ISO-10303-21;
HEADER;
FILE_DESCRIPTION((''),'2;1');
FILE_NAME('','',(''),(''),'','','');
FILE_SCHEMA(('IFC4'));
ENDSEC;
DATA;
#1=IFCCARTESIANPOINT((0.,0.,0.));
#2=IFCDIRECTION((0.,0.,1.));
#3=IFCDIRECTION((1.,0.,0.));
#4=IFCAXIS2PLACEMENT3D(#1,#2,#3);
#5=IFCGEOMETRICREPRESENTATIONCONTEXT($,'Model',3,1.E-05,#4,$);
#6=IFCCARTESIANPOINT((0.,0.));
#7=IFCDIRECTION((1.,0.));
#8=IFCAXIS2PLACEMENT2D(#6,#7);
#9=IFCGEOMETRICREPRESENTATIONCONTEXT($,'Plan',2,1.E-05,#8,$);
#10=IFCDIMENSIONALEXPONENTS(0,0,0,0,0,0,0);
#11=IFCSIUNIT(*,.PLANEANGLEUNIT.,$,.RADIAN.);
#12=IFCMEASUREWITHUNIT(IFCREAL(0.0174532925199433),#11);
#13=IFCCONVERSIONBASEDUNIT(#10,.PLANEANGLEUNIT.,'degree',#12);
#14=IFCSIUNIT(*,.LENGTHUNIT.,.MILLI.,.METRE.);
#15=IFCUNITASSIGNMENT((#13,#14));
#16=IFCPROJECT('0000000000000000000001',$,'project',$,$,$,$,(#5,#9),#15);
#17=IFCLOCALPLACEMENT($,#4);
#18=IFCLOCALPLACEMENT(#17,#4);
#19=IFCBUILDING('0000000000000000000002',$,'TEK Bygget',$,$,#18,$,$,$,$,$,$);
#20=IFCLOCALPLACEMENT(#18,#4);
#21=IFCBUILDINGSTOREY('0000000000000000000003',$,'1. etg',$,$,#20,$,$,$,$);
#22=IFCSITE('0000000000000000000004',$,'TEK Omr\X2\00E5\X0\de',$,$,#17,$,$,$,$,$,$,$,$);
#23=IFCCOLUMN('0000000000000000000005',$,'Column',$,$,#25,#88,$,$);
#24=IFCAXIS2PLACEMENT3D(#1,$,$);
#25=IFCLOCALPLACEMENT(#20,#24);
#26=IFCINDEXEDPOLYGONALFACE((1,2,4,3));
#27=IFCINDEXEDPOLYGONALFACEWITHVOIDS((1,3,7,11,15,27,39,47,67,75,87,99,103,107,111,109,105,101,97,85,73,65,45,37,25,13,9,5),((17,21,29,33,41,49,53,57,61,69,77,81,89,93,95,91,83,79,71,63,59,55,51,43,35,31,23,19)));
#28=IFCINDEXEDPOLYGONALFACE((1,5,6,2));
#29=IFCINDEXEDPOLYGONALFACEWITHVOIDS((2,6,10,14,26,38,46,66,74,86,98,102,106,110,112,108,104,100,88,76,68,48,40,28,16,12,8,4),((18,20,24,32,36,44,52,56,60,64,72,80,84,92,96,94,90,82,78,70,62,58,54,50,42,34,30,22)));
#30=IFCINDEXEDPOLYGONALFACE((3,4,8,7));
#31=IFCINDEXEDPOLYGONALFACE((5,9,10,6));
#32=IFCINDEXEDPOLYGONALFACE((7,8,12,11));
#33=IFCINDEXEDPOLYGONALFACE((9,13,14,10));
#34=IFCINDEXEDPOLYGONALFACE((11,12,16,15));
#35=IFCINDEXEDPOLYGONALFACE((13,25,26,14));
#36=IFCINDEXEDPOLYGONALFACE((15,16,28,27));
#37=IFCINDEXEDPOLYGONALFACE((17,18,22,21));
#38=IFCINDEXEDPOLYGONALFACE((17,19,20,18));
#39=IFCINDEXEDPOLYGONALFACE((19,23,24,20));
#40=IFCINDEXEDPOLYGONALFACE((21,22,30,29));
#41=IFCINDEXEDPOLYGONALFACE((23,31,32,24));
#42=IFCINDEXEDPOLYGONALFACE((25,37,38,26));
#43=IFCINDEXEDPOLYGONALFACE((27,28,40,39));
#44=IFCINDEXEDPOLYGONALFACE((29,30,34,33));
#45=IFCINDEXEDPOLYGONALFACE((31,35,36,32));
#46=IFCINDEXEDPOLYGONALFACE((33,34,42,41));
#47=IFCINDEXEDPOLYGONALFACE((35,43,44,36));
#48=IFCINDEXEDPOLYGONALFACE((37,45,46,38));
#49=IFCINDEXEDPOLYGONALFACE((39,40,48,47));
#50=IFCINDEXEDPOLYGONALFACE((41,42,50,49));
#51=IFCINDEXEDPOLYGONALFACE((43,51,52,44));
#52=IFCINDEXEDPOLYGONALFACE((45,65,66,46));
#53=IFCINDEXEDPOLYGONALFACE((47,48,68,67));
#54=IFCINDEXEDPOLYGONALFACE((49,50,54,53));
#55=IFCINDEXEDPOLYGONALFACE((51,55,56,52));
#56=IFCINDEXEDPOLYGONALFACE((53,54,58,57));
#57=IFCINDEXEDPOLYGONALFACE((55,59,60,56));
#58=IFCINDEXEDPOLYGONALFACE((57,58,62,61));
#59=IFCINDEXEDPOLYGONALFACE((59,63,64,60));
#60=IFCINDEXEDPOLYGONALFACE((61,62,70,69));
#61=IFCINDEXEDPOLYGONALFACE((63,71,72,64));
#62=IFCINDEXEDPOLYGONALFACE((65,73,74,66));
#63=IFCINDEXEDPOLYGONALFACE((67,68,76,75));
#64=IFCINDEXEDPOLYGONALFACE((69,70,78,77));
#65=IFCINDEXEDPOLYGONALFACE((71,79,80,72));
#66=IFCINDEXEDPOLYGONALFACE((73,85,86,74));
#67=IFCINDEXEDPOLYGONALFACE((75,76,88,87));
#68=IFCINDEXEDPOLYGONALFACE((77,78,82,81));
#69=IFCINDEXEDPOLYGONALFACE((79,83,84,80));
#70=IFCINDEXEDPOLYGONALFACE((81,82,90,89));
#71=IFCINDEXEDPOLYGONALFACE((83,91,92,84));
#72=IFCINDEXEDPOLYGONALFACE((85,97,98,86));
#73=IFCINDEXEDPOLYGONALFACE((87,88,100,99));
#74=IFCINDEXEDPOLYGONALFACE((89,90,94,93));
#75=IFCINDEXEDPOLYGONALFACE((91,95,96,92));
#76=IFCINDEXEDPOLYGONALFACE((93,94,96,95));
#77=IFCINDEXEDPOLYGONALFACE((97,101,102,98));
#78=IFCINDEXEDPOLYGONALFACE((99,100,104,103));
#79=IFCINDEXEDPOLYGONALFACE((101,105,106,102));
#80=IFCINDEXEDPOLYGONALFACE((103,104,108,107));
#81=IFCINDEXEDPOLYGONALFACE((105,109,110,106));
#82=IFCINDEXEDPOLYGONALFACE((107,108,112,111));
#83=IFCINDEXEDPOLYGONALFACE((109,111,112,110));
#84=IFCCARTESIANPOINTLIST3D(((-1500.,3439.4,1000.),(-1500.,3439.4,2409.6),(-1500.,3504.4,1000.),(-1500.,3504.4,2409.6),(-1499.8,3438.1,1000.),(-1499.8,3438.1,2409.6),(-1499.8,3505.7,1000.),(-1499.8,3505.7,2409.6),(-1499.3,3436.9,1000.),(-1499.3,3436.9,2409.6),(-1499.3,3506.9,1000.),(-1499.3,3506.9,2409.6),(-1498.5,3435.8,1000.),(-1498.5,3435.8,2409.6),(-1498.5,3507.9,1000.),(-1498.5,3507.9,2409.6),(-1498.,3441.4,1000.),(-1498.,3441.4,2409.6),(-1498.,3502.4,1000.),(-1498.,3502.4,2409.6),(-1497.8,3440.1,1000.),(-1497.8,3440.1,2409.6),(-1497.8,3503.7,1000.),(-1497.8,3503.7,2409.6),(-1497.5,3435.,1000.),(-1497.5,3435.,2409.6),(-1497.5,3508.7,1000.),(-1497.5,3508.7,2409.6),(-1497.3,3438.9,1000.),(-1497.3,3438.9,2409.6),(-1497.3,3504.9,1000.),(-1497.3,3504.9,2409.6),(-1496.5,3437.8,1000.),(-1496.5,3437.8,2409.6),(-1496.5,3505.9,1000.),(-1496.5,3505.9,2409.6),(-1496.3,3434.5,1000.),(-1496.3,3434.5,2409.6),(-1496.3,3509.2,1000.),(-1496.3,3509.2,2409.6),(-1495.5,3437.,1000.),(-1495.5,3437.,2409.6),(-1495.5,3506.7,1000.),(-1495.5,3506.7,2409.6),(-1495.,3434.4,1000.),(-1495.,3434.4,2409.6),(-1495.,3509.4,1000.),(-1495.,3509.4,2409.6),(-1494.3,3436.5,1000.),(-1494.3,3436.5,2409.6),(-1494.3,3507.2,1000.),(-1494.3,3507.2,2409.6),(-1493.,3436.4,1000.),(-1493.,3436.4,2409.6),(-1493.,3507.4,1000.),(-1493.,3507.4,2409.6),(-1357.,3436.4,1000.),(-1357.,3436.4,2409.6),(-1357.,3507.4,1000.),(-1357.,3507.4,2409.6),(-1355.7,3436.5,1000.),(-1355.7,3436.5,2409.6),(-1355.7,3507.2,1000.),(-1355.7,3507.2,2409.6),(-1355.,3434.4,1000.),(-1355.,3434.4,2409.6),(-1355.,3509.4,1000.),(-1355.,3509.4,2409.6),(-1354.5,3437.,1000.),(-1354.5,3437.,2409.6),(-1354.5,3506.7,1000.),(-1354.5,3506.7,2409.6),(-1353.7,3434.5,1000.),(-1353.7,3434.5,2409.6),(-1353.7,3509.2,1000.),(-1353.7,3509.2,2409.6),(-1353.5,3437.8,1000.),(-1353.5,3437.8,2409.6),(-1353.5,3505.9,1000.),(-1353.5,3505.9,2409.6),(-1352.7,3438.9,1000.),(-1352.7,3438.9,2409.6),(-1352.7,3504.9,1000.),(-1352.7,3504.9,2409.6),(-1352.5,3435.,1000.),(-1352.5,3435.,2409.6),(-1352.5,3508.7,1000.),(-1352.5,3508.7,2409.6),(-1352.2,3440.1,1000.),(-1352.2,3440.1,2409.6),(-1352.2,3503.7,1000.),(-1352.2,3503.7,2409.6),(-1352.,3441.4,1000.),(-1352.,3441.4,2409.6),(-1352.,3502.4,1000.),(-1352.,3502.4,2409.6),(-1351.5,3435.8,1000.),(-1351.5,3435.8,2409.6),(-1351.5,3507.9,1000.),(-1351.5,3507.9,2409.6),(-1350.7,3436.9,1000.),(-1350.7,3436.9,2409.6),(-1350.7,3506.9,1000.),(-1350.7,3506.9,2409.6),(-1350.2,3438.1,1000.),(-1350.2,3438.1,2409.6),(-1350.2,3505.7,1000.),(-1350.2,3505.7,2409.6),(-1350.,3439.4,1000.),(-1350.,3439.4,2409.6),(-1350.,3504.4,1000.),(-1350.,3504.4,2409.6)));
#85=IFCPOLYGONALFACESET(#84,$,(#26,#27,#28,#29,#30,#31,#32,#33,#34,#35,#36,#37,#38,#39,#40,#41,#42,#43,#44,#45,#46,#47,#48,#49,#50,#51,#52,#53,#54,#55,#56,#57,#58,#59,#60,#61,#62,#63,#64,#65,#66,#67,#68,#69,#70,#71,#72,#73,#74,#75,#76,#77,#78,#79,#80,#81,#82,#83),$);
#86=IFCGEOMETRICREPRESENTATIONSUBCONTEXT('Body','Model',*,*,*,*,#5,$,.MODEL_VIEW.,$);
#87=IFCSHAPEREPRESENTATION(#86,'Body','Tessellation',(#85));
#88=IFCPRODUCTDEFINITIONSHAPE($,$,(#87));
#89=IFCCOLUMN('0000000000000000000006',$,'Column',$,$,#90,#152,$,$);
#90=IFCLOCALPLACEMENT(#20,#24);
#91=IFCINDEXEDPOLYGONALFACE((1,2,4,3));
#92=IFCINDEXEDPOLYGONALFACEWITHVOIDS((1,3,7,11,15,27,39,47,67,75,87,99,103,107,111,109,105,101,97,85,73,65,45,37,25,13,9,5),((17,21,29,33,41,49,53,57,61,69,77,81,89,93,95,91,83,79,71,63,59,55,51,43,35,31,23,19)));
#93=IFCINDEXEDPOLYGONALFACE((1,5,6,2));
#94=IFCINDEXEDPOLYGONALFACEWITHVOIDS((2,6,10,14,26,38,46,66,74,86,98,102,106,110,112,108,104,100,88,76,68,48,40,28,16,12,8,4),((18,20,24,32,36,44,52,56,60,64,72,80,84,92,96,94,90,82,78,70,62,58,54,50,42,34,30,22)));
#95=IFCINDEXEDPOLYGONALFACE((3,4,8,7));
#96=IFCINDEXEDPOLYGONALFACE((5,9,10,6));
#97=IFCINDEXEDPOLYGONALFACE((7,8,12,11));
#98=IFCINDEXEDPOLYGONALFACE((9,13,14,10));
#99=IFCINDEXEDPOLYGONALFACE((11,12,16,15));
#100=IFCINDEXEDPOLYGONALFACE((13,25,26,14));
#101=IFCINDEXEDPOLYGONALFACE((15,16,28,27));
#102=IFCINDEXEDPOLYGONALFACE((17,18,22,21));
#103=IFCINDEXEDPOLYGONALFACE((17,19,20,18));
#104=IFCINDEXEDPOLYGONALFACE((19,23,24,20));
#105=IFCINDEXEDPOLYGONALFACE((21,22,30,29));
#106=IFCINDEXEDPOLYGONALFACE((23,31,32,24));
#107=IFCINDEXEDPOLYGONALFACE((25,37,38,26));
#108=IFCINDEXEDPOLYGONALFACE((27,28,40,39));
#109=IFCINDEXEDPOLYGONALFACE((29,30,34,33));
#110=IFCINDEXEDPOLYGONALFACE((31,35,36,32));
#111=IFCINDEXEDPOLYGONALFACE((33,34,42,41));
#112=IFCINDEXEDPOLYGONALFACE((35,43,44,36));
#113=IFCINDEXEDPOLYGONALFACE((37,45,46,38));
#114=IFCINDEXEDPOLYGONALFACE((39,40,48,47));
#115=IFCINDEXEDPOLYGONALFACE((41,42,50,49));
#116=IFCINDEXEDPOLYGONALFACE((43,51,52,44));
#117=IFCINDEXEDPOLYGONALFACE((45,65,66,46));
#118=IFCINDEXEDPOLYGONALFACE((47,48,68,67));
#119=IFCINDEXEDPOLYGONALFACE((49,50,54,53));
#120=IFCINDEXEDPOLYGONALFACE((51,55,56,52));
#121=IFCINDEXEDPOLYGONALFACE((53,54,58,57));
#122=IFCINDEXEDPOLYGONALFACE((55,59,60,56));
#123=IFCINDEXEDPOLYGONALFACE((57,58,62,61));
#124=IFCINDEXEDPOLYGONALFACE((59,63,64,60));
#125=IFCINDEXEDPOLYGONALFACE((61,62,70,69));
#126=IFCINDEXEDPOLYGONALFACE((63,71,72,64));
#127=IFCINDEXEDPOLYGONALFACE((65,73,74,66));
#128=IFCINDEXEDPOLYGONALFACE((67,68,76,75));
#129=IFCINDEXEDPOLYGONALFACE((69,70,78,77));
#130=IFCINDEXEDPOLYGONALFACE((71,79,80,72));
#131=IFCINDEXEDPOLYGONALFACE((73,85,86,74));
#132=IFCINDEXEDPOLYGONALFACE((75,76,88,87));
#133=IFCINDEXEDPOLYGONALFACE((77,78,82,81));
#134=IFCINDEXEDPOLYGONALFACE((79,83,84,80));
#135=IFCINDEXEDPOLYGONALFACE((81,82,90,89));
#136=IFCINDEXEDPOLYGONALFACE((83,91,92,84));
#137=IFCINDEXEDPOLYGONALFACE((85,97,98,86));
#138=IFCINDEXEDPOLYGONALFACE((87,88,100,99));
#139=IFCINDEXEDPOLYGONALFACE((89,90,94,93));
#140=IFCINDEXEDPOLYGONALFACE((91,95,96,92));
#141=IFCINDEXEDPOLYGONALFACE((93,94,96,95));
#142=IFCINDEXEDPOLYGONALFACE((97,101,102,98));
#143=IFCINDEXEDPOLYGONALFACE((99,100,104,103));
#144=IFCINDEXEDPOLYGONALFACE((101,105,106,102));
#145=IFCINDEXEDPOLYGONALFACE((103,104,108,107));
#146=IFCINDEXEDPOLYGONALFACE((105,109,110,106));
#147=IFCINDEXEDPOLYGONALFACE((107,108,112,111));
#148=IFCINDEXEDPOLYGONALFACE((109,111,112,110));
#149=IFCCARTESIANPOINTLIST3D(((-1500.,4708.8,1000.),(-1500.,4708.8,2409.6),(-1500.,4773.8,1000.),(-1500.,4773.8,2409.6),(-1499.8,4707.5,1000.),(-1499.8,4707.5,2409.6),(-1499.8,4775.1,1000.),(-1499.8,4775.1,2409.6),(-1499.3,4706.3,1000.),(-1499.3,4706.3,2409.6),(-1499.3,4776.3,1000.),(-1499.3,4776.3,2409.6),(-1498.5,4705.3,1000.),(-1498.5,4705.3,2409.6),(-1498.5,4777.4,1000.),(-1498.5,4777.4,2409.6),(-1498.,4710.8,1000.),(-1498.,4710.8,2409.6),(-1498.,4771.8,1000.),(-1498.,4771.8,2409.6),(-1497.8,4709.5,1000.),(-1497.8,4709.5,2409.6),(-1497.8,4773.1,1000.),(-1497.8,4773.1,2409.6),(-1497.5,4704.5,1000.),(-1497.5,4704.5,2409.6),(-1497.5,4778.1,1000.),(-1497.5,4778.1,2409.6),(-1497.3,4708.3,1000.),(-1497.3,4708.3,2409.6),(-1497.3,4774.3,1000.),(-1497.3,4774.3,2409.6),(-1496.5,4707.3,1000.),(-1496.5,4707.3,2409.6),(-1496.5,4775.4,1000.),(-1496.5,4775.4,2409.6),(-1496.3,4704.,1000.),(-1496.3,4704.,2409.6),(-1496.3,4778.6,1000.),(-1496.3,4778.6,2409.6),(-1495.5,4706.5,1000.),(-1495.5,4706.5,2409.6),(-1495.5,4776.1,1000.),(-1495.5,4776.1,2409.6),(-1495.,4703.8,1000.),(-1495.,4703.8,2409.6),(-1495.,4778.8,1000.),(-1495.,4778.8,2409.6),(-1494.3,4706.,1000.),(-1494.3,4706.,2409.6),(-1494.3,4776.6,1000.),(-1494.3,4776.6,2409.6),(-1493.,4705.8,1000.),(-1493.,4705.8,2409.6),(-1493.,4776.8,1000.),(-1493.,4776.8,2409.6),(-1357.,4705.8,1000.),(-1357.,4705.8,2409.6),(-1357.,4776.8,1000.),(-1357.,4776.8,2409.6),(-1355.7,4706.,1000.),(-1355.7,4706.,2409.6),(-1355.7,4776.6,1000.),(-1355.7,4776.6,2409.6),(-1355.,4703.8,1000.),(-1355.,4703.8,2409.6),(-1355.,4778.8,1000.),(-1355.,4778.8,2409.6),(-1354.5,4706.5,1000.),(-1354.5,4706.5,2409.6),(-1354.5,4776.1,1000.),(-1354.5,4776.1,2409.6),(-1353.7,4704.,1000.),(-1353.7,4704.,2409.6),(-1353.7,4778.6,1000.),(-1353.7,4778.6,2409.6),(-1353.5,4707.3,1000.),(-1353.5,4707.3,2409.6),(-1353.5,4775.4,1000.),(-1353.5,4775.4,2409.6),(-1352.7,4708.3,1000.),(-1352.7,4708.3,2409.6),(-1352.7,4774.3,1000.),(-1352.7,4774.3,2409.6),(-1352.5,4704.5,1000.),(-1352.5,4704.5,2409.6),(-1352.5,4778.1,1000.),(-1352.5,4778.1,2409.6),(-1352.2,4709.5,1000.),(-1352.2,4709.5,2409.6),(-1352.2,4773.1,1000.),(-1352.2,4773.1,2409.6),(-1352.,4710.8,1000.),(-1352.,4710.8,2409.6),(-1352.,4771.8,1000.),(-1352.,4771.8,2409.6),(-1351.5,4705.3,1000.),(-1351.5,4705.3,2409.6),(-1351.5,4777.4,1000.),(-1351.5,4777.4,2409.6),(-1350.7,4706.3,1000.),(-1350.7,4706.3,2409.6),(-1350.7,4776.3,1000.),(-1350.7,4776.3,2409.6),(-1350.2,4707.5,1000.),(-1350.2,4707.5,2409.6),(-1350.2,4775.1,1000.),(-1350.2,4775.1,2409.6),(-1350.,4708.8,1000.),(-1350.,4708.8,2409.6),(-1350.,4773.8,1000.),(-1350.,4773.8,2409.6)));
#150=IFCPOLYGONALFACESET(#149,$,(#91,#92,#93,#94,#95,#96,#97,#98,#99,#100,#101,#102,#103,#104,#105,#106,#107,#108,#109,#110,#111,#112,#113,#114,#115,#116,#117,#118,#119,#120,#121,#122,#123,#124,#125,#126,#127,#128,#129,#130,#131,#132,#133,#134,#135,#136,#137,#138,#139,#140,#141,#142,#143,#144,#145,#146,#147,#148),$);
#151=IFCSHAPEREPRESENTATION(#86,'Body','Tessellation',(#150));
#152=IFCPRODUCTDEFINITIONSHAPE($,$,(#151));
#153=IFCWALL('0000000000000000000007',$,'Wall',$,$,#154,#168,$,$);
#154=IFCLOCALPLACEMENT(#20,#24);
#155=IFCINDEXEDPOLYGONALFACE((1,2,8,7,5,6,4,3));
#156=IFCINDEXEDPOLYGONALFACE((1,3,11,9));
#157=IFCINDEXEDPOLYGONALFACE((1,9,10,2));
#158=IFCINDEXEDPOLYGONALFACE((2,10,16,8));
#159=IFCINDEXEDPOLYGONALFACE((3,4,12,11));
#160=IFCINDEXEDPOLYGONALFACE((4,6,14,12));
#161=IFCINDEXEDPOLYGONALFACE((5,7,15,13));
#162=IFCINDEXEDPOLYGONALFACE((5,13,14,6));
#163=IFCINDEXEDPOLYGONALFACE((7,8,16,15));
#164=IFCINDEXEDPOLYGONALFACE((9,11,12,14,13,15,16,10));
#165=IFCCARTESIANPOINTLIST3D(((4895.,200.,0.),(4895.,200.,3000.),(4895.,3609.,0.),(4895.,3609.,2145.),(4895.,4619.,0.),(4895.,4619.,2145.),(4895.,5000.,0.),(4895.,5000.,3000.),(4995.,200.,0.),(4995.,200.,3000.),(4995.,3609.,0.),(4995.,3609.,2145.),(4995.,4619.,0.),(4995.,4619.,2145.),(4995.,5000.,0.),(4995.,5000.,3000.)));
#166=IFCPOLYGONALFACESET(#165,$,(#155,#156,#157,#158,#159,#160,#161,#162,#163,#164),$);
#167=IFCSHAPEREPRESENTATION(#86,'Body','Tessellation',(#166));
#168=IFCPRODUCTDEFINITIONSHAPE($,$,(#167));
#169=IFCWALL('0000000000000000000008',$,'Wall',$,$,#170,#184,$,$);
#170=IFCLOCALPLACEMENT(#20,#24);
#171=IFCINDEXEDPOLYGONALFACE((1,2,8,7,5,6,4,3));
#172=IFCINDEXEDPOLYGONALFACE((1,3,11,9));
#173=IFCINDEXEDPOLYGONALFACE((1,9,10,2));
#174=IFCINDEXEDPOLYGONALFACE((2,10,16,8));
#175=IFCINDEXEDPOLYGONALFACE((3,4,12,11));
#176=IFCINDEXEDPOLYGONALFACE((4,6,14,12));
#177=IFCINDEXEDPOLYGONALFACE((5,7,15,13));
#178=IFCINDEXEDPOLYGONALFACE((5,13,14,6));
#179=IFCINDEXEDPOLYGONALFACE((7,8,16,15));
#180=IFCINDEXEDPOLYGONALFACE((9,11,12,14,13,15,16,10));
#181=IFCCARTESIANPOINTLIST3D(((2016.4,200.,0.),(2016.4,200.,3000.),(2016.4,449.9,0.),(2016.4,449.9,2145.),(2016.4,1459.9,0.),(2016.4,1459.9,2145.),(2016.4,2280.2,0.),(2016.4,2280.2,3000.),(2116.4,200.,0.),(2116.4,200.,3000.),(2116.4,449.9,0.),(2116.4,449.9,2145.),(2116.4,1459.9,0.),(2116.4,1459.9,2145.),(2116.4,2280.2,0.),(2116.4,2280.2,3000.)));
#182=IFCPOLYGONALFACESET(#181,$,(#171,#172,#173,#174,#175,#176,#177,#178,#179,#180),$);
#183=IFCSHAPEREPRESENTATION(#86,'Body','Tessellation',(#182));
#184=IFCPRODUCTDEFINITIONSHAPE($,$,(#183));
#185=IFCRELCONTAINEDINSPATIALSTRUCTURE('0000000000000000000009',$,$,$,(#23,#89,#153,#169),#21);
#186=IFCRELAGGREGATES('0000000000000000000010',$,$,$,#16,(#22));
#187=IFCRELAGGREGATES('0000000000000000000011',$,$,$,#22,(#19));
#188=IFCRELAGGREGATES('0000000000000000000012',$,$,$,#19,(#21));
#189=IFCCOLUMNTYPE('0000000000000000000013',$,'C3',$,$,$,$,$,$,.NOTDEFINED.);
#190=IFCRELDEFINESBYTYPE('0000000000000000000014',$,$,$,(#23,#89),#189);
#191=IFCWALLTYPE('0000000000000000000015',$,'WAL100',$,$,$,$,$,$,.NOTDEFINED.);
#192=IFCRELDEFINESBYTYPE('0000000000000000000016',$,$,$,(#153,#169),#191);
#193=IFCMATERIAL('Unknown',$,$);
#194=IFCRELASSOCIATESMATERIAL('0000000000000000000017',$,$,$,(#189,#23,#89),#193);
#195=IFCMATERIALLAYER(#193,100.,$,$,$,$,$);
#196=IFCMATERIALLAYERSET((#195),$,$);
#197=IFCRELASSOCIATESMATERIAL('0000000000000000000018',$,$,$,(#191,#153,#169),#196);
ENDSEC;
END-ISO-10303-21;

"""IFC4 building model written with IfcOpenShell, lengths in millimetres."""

from ifc_helpers import new_model, entity, si_unit, converted_unit, frame, origin_with_axes, origin_2d_with_axis, place, context, subcontext, project, spatial, line, indexed_curve, hollow_rectangle, outline, extrude, source, transform, mapped, material, layer, layer_set, layer_usage, material_profile, profile_set, profile_usage, type_object, element, save


model = new_model("IFC4")

# Units and contexts
model_context = context("Model", 3, precision=1e-05, world=origin_with_axes())
plan_context = context("Plan", 2, precision=1e-05, world=origin_2d_with_axis())
body_context = subcontext(model_context, "Body", "Model", "MODEL_VIEW")
ifc_project = project(units=[converted_unit("PLANEANGLEUNIT", "degree", entity("IfcReal", 0.0174532925199433), si_unit("PLANEANGLEUNIT", "RADIAN"), dimensions=[0, 0, 0, 0, 0, 0, 0]), si_unit("LENGTHUNIT", "METRE", prefix="MILLI")], contexts=[model_context, plan_context])

# Site, building, storey
site_placement = place(None, origin_with_axes())
site = spatial("IfcSite", under=ifc_project, at=site_placement, Name="TEK Område")
building_placement = place(site_placement, origin_with_axes())
building = spatial("IfcBuilding", under=site, at=building_placement, Name="TEK Bygget")
storey_placement = place(building_placement, origin_with_axes())
storey = spatial("IfcBuildingStorey", under=building, at=storey_placement, Name="1. etg")

# Columns
ifc_material = material(Name="Unknown")
ifc_material_profile = material_profile(ifc_material, hollow_rectangle(XDim=75.0, YDim=150.0, WallThickness=2.0, InnerFilletRadius=5.0, OuterFilletRadius=5.0))
ifc_profile_set = profile_set([ifc_material_profile])
ifc_profile_usage_1 = profile_usage(ifc_profile_set, cardinal=5)
column_type = type_object("IfcColumnType", Name="C3", PredefinedType="NOTDEFINED", material=ifc_profile_set)
column_1_placement = place(storey_placement, frame((-1425.0, 3471.9, 1000.0), z_axis=(0.0, 0.0, 1.0), x_axis=(0.0, 1.0, 0.0)))
element("IfcColumn", 1, at=column_1_placement, inside=storey, type_object=column_type, material=ifc_profile_usage_1, Name="Column", context=body_context, shape_type="SweptSolid", body=[
    extrude(hollow_rectangle(XDim=75.0, YDim=150.0, WallThickness=2.0, InnerFilletRadius=5.0, OuterFilletRadius=5.0), origin_with_axes(), (0.0, 0.0, 1.0), 1409.6),
])
ifc_profile_usage_2 = profile_usage(ifc_profile_set, cardinal=5)
column_2_placement = place(storey_placement, frame((-1425.0, 4741.3, 1000.0), z_axis=(0.0, 0.0, 1.0), x_axis=(0.0, 1.0, 0.0)))
element("IfcColumn", 2, at=column_2_placement, inside=storey, type_object=column_type, material=ifc_profile_usage_2, Name="Column", context=body_context, shape_type="SweptSolid", body=[
    extrude(hollow_rectangle(XDim=75.0, YDim=150.0, WallThickness=2.0, InnerFilletRadius=5.0, OuterFilletRadius=5.0), origin_with_axes(), (0.0, 0.0, 1.0), 1409.6),
])

# Walls, openings
ifc_layer_1 = layer(ifc_material, 100.0)
ifc_layer_set_1 = layer_set([ifc_layer_1])
ifc_layer_usage_1 = layer_usage(ifc_layer_set_1, "AXIS2", "POSITIVE", 0.0)
wall_type_1 = type_object("IfcWallType", Name="WAL100", PredefinedType="NOTDEFINED", material=ifc_layer_set_1)
wall_1_placement = place(storey_placement, frame((4995.0, 200.0, 0.0), z_axis=(0.0, 0.0, 1.0), x_axis=(0.0, 1.0, 0.0)))
wall_1 = element("IfcWall", 3, at=wall_1_placement, inside=storey, type_object=wall_type_1, material=ifc_layer_usage_1, Name="Wall", context=body_context, shape_type="SweptSolid", body=[
    extrude(outline(indexed_curve([(0.0, 0.0), (0.0, 100.0), (4800.0, 100.0), (4800.0, 0.0), (0.0, 0.0)], self_intersect=False)), origin_with_axes(), (0.0, 0.0, 1.0), 3000.0),
])
shared_shape_1 = source(origin_with_axes(), body_context, "Body", "SweptSolid", [
    extrude(outline(indexed_curve([(0.0, 0.0), (1010.0, 0.0), (1010.0, 2145.0), (0.0, 2145.0)], segments=[line(1, 2), line(2, 3), line(3, 4), line(4, 1)])), frame((0.0, -100.0, 0.0), z_axis=(0.0, -1.0, 0.0), x_axis=(1.0, 0.0, 0.0)), (0.0, 0.0, -1.0), 400.0),
])
opening_1_placement = place(wall_1_placement, frame((3409.0, 0.0, 0.0), z_axis=(0.0, 0.0, 1.0), x_axis=(1.0, 0.0, 0.0)))
element("IfcOpeningElement", 4, at=opening_1_placement, cuts=wall_1, PredefinedType="OPENING", context=body_context, shape_type="MappedRepresentation", body=[
    mapped(shared_shape_1, transform((0.0, 0.0, 0.0), x_axis=(1.0, 0.0, 0.0), y_axis=(0.0, 1.0, 0.0), z_axis=(0.0, 0.0, 1.0), scale=1.0)),
])
ifc_layer_usage_2 = layer_usage(ifc_layer_set_1, "AXIS2", "POSITIVE", 0.0)
wall_2_placement = place(storey_placement, frame((2116.4, 200.0, 0.0), z_axis=(0.0, 0.0, 1.0), x_axis=(0.000001, 1.0, 0.0)))
wall_2 = element("IfcWall", 5, at=wall_2_placement, inside=storey, type_object=wall_type_1, material=ifc_layer_usage_2, Name="Wall", context=body_context, shape_type="SweptSolid", body=[
    extrude(outline(indexed_curve([(0.0, 0.0), (0.0, 100.0), (2080.2, 100.0), (2080.2, 0.0), (0.0, 0.0)], self_intersect=False)), origin_with_axes(), (0.0, 0.0, 1.0), 3000.0),
])
opening_2_placement = place(wall_2_placement, frame((249.9, 0.0, 0.0), z_axis=(0.0, 0.0, 1.0), x_axis=(1.0, 0.0, 0.0)))
element("IfcOpeningElement", 6, at=opening_2_placement, cuts=wall_2, PredefinedType="OPENING", context=body_context, shape_type="MappedRepresentation", body=[
    mapped(shared_shape_1, transform((0.0, 0.0, 0.0), x_axis=(1.0, 0.0, 0.0), y_axis=(0.0, 1.0, 0.0), z_axis=(0.0, 0.0, 1.0), scale=1.0)),
])

save(model, "model.ifc")
